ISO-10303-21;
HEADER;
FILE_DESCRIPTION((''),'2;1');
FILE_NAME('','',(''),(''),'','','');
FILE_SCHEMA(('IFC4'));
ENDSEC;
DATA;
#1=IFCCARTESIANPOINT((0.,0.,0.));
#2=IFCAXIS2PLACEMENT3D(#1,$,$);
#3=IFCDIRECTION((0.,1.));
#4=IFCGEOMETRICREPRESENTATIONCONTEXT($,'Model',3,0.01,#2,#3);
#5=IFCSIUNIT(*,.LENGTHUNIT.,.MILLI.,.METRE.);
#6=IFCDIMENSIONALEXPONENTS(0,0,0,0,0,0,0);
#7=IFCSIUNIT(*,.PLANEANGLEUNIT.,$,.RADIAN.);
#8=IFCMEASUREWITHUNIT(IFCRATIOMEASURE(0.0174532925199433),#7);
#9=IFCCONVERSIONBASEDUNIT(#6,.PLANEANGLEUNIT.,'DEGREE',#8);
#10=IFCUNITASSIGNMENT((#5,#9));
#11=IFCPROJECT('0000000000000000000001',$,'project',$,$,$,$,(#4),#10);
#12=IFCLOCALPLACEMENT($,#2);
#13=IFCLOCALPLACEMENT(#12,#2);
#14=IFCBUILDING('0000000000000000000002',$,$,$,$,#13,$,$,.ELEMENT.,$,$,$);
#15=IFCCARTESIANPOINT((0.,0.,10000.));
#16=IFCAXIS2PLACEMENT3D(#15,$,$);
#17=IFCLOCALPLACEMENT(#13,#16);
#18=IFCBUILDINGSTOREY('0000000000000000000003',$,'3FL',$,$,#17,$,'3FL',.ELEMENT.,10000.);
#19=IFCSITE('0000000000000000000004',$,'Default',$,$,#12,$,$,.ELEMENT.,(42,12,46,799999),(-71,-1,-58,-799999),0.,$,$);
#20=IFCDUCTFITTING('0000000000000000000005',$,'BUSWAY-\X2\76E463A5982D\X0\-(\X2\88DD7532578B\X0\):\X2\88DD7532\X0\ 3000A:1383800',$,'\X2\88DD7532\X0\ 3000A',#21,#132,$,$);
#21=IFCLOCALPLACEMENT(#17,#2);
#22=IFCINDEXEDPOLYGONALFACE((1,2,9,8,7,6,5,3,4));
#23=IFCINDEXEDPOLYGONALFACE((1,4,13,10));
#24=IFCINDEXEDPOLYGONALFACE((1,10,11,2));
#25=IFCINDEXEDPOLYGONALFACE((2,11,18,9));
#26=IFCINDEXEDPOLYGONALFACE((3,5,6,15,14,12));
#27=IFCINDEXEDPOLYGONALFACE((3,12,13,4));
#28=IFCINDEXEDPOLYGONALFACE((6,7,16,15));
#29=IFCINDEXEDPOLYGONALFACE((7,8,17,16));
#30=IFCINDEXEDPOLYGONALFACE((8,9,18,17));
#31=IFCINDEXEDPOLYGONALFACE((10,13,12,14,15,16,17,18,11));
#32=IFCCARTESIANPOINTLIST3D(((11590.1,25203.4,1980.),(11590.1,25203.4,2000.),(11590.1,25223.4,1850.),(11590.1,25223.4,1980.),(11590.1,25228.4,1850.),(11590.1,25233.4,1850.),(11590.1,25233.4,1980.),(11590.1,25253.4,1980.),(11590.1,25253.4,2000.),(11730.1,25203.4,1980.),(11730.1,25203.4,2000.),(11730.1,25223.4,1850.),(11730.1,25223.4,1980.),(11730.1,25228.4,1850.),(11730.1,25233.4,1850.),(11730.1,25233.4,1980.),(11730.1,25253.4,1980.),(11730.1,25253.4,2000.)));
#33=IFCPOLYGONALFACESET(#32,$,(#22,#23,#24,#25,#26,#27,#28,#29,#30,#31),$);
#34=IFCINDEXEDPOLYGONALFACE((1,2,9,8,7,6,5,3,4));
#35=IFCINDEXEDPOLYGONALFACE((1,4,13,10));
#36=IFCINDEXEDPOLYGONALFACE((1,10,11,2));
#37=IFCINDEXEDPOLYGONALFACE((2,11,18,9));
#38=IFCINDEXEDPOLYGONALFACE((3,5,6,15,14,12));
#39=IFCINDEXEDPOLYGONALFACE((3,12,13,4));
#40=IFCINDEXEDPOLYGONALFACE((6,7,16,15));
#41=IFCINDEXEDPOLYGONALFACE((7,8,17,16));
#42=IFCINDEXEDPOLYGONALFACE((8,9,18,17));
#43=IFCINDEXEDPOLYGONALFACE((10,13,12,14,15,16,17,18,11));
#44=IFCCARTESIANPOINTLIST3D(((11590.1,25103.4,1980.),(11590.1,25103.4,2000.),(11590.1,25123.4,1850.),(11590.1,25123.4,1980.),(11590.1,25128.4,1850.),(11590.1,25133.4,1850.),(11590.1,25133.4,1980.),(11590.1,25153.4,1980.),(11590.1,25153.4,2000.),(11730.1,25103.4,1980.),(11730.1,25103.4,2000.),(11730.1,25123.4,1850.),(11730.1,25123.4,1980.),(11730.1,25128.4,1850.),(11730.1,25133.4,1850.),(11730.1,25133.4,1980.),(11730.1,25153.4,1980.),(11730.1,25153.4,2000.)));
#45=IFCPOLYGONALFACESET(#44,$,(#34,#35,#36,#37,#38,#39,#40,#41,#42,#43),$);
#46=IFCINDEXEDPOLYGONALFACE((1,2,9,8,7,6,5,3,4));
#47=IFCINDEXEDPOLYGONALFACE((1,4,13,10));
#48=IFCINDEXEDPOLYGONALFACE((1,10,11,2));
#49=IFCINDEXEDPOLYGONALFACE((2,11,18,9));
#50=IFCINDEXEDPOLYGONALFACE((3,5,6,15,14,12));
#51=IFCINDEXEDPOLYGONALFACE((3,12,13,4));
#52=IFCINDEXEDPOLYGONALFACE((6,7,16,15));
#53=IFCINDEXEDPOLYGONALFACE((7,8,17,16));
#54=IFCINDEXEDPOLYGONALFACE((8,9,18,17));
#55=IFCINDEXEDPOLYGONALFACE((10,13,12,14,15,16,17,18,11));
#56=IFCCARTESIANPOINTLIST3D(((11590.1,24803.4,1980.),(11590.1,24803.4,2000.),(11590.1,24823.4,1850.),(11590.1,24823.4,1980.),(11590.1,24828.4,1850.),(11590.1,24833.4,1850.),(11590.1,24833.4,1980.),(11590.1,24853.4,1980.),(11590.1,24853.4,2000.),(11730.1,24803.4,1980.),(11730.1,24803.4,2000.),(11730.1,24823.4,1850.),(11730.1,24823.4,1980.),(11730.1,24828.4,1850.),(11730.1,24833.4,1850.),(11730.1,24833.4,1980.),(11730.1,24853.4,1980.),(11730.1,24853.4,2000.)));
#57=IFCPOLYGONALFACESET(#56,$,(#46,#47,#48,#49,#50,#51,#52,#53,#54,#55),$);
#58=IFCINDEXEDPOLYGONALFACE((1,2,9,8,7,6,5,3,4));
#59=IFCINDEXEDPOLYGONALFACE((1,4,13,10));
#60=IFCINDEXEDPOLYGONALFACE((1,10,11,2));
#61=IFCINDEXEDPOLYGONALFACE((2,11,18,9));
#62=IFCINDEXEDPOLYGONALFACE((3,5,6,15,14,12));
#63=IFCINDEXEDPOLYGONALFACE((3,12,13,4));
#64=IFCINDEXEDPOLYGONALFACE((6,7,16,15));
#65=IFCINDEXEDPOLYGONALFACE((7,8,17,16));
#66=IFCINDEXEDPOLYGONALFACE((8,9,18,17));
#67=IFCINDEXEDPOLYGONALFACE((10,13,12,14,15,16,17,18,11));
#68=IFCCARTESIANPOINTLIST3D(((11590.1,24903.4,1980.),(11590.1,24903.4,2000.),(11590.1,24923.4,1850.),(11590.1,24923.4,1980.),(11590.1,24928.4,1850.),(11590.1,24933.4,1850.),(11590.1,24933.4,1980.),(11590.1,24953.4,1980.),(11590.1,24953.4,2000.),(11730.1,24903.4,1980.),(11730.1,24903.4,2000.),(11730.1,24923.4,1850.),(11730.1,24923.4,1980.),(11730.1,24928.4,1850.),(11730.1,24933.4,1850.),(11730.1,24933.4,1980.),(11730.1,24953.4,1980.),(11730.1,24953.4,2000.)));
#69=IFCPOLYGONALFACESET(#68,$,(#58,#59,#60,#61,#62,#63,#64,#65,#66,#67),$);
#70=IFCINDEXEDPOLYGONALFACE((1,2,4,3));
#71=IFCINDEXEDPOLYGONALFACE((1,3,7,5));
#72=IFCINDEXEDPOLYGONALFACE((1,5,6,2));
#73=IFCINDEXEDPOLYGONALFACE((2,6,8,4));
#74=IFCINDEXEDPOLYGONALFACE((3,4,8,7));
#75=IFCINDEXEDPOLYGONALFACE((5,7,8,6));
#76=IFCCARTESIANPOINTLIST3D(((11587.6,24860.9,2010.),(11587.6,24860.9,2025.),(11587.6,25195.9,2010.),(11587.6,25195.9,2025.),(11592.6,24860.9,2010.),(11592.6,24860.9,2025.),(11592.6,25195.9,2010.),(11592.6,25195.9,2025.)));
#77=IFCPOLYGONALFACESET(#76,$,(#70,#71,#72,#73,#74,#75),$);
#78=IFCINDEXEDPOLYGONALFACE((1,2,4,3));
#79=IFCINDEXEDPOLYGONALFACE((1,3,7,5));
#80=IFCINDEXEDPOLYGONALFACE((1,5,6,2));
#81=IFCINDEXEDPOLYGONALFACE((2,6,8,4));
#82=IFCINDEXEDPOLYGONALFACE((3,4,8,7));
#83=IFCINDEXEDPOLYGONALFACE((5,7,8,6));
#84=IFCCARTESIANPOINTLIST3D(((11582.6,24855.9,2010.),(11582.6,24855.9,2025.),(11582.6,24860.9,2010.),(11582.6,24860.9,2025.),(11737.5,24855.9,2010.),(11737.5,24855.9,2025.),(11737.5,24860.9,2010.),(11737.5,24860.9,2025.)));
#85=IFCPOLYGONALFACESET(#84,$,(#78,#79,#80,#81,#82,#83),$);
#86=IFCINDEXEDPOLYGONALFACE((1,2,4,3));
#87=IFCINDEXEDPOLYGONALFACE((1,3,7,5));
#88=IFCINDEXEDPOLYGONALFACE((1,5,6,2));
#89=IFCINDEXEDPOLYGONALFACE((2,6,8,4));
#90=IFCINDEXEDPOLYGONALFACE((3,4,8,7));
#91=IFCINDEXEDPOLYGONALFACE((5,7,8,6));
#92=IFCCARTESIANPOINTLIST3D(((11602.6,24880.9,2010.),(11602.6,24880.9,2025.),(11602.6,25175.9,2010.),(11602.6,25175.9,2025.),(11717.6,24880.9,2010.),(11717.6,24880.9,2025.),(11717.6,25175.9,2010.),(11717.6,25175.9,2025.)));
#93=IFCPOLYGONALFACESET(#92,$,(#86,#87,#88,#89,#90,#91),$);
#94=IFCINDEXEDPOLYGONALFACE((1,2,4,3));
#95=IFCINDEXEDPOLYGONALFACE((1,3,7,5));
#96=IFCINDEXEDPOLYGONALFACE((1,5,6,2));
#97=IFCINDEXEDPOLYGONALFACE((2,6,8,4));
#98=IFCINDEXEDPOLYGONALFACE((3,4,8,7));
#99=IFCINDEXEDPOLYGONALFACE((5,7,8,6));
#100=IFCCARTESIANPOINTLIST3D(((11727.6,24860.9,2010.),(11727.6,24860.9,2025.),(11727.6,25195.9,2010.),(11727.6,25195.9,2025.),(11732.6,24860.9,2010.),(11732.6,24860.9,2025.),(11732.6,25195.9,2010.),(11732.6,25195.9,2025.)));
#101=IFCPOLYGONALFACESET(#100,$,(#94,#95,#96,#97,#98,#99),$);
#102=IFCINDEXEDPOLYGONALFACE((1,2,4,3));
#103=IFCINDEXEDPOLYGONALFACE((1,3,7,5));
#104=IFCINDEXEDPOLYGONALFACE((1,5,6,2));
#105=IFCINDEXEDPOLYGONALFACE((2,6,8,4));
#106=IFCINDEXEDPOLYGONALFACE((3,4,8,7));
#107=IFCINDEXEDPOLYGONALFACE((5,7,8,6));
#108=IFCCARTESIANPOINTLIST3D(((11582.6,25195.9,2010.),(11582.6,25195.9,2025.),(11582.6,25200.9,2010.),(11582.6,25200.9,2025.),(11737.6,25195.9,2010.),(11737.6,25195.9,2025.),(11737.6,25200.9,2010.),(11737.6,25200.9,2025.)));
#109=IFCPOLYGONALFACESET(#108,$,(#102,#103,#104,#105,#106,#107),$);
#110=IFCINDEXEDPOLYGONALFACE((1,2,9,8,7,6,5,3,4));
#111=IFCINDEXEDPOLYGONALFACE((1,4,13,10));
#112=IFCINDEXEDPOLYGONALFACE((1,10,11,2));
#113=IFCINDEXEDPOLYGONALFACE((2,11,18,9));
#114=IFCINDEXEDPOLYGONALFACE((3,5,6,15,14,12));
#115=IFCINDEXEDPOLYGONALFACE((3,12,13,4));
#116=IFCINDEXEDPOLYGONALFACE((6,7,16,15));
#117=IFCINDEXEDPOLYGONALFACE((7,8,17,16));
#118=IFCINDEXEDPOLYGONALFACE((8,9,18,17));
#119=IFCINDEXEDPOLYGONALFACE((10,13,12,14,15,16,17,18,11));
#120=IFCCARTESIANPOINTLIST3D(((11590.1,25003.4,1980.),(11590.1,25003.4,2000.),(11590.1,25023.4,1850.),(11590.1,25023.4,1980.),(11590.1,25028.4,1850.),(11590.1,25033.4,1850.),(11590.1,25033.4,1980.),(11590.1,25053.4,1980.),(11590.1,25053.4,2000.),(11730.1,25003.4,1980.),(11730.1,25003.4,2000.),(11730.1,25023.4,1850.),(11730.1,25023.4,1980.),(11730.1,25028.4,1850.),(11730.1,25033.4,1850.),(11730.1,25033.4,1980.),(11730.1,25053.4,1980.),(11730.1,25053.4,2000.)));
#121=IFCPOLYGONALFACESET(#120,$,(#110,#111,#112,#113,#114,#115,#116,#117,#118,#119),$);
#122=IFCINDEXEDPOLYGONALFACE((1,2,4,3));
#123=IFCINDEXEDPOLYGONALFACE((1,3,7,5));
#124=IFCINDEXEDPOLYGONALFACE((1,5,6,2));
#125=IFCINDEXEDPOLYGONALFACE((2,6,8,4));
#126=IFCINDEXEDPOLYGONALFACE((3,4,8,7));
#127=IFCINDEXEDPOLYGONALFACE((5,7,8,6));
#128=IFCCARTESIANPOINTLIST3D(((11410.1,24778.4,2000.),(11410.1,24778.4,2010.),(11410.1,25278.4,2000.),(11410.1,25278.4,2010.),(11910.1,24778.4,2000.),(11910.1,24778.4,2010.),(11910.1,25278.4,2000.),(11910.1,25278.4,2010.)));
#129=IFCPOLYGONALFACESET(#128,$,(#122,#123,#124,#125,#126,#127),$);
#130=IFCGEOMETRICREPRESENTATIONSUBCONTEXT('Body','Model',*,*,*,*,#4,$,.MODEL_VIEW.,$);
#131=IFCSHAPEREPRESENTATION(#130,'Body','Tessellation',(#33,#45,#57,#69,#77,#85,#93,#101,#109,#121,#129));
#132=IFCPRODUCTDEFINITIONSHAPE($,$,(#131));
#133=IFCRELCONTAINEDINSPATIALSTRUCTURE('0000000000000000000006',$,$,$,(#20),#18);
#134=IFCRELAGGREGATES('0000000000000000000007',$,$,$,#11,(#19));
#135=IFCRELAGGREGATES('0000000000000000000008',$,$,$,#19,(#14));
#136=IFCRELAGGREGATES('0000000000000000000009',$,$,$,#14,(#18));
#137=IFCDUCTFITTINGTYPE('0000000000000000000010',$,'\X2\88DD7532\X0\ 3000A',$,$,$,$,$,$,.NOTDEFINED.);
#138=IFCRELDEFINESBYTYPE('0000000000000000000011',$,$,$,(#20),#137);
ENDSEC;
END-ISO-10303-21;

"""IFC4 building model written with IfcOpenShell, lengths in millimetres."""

from ifc_helpers import new_model, entity, si_unit, converted_unit, direction, frame, frame_2d, origin, origin_2d_with_axis, place, context, subcontext, project, spatial, polyline, rectangle, outline, extrude, source, transform, mapped, type_object, type_shapes, element, save


model = new_model("IFC4")

# Units and contexts
model_context = context("Model", 3, precision=0.01, world=origin(), true_north=direction((0.0, 1.0)))
body_context = subcontext(model_context, "Body", "Model", "MODEL_VIEW")
ifc_project = project(units=[si_unit("LENGTHUNIT", "METRE", prefix="MILLI"), converted_unit("PLANEANGLEUNIT", "DEGREE", entity("IfcRatioMeasure", 0.0174532925199433), si_unit("PLANEANGLEUNIT", "RADIAN"), dimensions=[0, 0, 0, 0, 0, 0, 0])], contexts=[model_context])

# Site, building, storey
site_placement = place(None, origin())
site = spatial("IfcSite", under=ifc_project, at=site_placement, Name="Default", CompositionType="ELEMENT", RefLatitude=(42, 12, 46, 799999), RefLongitude=(-71, -1, -58, -799999), RefElevation=0.0)
building_placement = place(site_placement, origin())
building = spatial("IfcBuilding", under=site, at=building_placement, CompositionType="ELEMENT")
storey_placement = place(building_placement, frame((0.0, 0.0, 10000.0)))
storey = spatial("IfcBuildingStorey", under=building, at=storey_placement, Name="3FL", LongName="3FL", CompositionType="ELEMENT", Elevation=10000.0)

# Duct fitting
duct_fitting_type_1 = type_object("IfcDuctFittingType", Name="裝甲 3000A", PredefinedType="NOTDEFINED")
shared_shape_1 = source(origin(), body_context, "Body", "SweptSolid", [
    extrude(outline(polyline([(-25.0, -58.9), (25.0, -58.9), (25.0, -38.9), (5.0, -38.9), (5.0, 91.1), (0.0, 91.1), (-5.0, 91.1), (-5.0, -38.9), (-25.0, -38.9), (-25.0, -58.9)])), frame((-200.0, -70.0, -58.9), z_axis=(0.0, 1.0, 0.0), x_axis=(1.0, 0.0, 0.0)), (0.0, 0.0, 1.0), 140.0),
    extrude(outline(polyline([(-25.0, -58.9), (25.0, -58.9), (25.0, -38.9), (5.0, -38.9), (5.0, 91.1), (0.0, 91.1), (-5.0, 91.1), (-5.0, -38.9), (-25.0, -38.9), (-25.0, -58.9)])), frame((-100.0, -70.0, -58.9), z_axis=(0.0, 1.0, 0.0), x_axis=(1.0, 0.0, 0.0)), (0.0, 0.0, 1.0), 140.0),
    extrude(outline(polyline([(-58.9, -25.0), (-38.9, -25.0), (-38.9, -5.0), (91.1, -5.0), (91.1, 0.0), (91.1, 5.0), (-38.9, 5.0), (-38.9, 25.0), (-58.9, 25.0), (-58.9, -25.0)])), frame((200.0, -70.0, -58.9), z_axis=(0.0, 1.0, 0.0), x_axis=(0.0, 0.0, -1.0)), (0.0, 0.0, 1.0), 140.0),
    extrude(outline(polyline([(-58.9, -25.0), (-38.9, -25.0), (-38.9, -5.0), (91.1, -5.0), (91.1, 0.0), (91.1, 5.0), (-38.9, 5.0), (-38.9, 25.0), (-58.9, 25.0), (-58.9, -25.0)])), frame((100.0, -70.0, -58.9), z_axis=(0.0, 1.0, 0.0), x_axis=(0.0, 0.0, -1.0)), (0.0, 0.0, 1.0), 140.0),
    extrude(rectangle(XDim=335.0, YDim=5.0, at=origin_2d_with_axis()), frame((0.0, -70.0, 10.0), z_axis=(0.0, 0.0, 1.0), x_axis=(-1.0, 0.0, 0.0)), (0.0, 0.0, 1.0), 15.0),
    extrude(rectangle(XDim=5.0, YDim=154.9, at=frame_2d((0.0, 0.0), x_axis=(1.0, 0.0))), frame((170.0, -0.1, 10.0), z_axis=(0.0, 0.0, 1.0), x_axis=(-1.0, 0.0, 0.0)), (0.0, 0.0, 1.0), 15.0),
    extrude(rectangle(XDim=295.0, YDim=115.0, at=origin_2d_with_axis()), frame((0.0, 0.0, 10.0), z_axis=(0.0, 0.0, 1.0), x_axis=(-1.0, 0.0, 0.0)), (0.0, 0.0, 1.0), 15.0),
    extrude(rectangle(XDim=335.0, YDim=5.0, at=origin_2d_with_axis()), frame((0.0, 70.0, 10.0), z_axis=(0.0, 0.0, 1.0), x_axis=(-1.0, 0.0, 0.0)), (0.0, 0.0, 1.0), 15.0),
    extrude(rectangle(XDim=5.0, YDim=155.0, at=origin_2d_with_axis()), frame((-170.0, 0.0, 10.0), z_axis=(0.0, 0.0, 1.0), x_axis=(-1.0, 0.0, 0.0)), (0.0, 0.0, 1.0), 15.0),
    extrude(outline(polyline([(-58.9, -25.0), (-38.9, -25.0), (-38.9, -5.0), (91.1, -5.0), (91.1, 0.0), (91.1, 5.0), (-38.9, 5.0), (-38.9, 25.0), (-58.9, 25.0), (-58.9, -25.0)])), frame((0.0, -70.0, -58.9), z_axis=(0.0, 1.0, 0.0), x_axis=(0.0, 0.0, -1.0)), (0.0, 0.0, 1.0), 140.0),
    extrude(rectangle(XDim=500.0, YDim=500.0, at=origin_2d_with_axis()), frame((0.0, 0.0, 0.0), z_axis=(0.0, 0.0, 1.0), x_axis=(0.0, 1.0, 0.0)), (0.0, 0.0, 1.0), 10.0),
])
type_shapes(duct_fitting_type_1, [shared_shape_1])
for number, where, z_axis, x_axis, name in (
    (1, (11660.1, 25028.4, 2000.0), (0.0, 0.0, 1.0), (0.0, -1.0, 0.0), "BUSWAY-盤接頭-(裝甲型):裝甲 3000A:1383800"),
):
    element("IfcDuctFitting", number, at=place(storey_placement, frame(where, z_axis=z_axis, x_axis=x_axis)), inside=storey, type_object=duct_fitting_type_1, Name=name, ObjectType="裝甲 3000A", context=body_context, shape_type="MappedRepresentation", body=[
        mapped(shared_shape_1, transform((0.0, 0.0, 0.0), scale=1.0)),
    ])

save(model, "model.ifc")
